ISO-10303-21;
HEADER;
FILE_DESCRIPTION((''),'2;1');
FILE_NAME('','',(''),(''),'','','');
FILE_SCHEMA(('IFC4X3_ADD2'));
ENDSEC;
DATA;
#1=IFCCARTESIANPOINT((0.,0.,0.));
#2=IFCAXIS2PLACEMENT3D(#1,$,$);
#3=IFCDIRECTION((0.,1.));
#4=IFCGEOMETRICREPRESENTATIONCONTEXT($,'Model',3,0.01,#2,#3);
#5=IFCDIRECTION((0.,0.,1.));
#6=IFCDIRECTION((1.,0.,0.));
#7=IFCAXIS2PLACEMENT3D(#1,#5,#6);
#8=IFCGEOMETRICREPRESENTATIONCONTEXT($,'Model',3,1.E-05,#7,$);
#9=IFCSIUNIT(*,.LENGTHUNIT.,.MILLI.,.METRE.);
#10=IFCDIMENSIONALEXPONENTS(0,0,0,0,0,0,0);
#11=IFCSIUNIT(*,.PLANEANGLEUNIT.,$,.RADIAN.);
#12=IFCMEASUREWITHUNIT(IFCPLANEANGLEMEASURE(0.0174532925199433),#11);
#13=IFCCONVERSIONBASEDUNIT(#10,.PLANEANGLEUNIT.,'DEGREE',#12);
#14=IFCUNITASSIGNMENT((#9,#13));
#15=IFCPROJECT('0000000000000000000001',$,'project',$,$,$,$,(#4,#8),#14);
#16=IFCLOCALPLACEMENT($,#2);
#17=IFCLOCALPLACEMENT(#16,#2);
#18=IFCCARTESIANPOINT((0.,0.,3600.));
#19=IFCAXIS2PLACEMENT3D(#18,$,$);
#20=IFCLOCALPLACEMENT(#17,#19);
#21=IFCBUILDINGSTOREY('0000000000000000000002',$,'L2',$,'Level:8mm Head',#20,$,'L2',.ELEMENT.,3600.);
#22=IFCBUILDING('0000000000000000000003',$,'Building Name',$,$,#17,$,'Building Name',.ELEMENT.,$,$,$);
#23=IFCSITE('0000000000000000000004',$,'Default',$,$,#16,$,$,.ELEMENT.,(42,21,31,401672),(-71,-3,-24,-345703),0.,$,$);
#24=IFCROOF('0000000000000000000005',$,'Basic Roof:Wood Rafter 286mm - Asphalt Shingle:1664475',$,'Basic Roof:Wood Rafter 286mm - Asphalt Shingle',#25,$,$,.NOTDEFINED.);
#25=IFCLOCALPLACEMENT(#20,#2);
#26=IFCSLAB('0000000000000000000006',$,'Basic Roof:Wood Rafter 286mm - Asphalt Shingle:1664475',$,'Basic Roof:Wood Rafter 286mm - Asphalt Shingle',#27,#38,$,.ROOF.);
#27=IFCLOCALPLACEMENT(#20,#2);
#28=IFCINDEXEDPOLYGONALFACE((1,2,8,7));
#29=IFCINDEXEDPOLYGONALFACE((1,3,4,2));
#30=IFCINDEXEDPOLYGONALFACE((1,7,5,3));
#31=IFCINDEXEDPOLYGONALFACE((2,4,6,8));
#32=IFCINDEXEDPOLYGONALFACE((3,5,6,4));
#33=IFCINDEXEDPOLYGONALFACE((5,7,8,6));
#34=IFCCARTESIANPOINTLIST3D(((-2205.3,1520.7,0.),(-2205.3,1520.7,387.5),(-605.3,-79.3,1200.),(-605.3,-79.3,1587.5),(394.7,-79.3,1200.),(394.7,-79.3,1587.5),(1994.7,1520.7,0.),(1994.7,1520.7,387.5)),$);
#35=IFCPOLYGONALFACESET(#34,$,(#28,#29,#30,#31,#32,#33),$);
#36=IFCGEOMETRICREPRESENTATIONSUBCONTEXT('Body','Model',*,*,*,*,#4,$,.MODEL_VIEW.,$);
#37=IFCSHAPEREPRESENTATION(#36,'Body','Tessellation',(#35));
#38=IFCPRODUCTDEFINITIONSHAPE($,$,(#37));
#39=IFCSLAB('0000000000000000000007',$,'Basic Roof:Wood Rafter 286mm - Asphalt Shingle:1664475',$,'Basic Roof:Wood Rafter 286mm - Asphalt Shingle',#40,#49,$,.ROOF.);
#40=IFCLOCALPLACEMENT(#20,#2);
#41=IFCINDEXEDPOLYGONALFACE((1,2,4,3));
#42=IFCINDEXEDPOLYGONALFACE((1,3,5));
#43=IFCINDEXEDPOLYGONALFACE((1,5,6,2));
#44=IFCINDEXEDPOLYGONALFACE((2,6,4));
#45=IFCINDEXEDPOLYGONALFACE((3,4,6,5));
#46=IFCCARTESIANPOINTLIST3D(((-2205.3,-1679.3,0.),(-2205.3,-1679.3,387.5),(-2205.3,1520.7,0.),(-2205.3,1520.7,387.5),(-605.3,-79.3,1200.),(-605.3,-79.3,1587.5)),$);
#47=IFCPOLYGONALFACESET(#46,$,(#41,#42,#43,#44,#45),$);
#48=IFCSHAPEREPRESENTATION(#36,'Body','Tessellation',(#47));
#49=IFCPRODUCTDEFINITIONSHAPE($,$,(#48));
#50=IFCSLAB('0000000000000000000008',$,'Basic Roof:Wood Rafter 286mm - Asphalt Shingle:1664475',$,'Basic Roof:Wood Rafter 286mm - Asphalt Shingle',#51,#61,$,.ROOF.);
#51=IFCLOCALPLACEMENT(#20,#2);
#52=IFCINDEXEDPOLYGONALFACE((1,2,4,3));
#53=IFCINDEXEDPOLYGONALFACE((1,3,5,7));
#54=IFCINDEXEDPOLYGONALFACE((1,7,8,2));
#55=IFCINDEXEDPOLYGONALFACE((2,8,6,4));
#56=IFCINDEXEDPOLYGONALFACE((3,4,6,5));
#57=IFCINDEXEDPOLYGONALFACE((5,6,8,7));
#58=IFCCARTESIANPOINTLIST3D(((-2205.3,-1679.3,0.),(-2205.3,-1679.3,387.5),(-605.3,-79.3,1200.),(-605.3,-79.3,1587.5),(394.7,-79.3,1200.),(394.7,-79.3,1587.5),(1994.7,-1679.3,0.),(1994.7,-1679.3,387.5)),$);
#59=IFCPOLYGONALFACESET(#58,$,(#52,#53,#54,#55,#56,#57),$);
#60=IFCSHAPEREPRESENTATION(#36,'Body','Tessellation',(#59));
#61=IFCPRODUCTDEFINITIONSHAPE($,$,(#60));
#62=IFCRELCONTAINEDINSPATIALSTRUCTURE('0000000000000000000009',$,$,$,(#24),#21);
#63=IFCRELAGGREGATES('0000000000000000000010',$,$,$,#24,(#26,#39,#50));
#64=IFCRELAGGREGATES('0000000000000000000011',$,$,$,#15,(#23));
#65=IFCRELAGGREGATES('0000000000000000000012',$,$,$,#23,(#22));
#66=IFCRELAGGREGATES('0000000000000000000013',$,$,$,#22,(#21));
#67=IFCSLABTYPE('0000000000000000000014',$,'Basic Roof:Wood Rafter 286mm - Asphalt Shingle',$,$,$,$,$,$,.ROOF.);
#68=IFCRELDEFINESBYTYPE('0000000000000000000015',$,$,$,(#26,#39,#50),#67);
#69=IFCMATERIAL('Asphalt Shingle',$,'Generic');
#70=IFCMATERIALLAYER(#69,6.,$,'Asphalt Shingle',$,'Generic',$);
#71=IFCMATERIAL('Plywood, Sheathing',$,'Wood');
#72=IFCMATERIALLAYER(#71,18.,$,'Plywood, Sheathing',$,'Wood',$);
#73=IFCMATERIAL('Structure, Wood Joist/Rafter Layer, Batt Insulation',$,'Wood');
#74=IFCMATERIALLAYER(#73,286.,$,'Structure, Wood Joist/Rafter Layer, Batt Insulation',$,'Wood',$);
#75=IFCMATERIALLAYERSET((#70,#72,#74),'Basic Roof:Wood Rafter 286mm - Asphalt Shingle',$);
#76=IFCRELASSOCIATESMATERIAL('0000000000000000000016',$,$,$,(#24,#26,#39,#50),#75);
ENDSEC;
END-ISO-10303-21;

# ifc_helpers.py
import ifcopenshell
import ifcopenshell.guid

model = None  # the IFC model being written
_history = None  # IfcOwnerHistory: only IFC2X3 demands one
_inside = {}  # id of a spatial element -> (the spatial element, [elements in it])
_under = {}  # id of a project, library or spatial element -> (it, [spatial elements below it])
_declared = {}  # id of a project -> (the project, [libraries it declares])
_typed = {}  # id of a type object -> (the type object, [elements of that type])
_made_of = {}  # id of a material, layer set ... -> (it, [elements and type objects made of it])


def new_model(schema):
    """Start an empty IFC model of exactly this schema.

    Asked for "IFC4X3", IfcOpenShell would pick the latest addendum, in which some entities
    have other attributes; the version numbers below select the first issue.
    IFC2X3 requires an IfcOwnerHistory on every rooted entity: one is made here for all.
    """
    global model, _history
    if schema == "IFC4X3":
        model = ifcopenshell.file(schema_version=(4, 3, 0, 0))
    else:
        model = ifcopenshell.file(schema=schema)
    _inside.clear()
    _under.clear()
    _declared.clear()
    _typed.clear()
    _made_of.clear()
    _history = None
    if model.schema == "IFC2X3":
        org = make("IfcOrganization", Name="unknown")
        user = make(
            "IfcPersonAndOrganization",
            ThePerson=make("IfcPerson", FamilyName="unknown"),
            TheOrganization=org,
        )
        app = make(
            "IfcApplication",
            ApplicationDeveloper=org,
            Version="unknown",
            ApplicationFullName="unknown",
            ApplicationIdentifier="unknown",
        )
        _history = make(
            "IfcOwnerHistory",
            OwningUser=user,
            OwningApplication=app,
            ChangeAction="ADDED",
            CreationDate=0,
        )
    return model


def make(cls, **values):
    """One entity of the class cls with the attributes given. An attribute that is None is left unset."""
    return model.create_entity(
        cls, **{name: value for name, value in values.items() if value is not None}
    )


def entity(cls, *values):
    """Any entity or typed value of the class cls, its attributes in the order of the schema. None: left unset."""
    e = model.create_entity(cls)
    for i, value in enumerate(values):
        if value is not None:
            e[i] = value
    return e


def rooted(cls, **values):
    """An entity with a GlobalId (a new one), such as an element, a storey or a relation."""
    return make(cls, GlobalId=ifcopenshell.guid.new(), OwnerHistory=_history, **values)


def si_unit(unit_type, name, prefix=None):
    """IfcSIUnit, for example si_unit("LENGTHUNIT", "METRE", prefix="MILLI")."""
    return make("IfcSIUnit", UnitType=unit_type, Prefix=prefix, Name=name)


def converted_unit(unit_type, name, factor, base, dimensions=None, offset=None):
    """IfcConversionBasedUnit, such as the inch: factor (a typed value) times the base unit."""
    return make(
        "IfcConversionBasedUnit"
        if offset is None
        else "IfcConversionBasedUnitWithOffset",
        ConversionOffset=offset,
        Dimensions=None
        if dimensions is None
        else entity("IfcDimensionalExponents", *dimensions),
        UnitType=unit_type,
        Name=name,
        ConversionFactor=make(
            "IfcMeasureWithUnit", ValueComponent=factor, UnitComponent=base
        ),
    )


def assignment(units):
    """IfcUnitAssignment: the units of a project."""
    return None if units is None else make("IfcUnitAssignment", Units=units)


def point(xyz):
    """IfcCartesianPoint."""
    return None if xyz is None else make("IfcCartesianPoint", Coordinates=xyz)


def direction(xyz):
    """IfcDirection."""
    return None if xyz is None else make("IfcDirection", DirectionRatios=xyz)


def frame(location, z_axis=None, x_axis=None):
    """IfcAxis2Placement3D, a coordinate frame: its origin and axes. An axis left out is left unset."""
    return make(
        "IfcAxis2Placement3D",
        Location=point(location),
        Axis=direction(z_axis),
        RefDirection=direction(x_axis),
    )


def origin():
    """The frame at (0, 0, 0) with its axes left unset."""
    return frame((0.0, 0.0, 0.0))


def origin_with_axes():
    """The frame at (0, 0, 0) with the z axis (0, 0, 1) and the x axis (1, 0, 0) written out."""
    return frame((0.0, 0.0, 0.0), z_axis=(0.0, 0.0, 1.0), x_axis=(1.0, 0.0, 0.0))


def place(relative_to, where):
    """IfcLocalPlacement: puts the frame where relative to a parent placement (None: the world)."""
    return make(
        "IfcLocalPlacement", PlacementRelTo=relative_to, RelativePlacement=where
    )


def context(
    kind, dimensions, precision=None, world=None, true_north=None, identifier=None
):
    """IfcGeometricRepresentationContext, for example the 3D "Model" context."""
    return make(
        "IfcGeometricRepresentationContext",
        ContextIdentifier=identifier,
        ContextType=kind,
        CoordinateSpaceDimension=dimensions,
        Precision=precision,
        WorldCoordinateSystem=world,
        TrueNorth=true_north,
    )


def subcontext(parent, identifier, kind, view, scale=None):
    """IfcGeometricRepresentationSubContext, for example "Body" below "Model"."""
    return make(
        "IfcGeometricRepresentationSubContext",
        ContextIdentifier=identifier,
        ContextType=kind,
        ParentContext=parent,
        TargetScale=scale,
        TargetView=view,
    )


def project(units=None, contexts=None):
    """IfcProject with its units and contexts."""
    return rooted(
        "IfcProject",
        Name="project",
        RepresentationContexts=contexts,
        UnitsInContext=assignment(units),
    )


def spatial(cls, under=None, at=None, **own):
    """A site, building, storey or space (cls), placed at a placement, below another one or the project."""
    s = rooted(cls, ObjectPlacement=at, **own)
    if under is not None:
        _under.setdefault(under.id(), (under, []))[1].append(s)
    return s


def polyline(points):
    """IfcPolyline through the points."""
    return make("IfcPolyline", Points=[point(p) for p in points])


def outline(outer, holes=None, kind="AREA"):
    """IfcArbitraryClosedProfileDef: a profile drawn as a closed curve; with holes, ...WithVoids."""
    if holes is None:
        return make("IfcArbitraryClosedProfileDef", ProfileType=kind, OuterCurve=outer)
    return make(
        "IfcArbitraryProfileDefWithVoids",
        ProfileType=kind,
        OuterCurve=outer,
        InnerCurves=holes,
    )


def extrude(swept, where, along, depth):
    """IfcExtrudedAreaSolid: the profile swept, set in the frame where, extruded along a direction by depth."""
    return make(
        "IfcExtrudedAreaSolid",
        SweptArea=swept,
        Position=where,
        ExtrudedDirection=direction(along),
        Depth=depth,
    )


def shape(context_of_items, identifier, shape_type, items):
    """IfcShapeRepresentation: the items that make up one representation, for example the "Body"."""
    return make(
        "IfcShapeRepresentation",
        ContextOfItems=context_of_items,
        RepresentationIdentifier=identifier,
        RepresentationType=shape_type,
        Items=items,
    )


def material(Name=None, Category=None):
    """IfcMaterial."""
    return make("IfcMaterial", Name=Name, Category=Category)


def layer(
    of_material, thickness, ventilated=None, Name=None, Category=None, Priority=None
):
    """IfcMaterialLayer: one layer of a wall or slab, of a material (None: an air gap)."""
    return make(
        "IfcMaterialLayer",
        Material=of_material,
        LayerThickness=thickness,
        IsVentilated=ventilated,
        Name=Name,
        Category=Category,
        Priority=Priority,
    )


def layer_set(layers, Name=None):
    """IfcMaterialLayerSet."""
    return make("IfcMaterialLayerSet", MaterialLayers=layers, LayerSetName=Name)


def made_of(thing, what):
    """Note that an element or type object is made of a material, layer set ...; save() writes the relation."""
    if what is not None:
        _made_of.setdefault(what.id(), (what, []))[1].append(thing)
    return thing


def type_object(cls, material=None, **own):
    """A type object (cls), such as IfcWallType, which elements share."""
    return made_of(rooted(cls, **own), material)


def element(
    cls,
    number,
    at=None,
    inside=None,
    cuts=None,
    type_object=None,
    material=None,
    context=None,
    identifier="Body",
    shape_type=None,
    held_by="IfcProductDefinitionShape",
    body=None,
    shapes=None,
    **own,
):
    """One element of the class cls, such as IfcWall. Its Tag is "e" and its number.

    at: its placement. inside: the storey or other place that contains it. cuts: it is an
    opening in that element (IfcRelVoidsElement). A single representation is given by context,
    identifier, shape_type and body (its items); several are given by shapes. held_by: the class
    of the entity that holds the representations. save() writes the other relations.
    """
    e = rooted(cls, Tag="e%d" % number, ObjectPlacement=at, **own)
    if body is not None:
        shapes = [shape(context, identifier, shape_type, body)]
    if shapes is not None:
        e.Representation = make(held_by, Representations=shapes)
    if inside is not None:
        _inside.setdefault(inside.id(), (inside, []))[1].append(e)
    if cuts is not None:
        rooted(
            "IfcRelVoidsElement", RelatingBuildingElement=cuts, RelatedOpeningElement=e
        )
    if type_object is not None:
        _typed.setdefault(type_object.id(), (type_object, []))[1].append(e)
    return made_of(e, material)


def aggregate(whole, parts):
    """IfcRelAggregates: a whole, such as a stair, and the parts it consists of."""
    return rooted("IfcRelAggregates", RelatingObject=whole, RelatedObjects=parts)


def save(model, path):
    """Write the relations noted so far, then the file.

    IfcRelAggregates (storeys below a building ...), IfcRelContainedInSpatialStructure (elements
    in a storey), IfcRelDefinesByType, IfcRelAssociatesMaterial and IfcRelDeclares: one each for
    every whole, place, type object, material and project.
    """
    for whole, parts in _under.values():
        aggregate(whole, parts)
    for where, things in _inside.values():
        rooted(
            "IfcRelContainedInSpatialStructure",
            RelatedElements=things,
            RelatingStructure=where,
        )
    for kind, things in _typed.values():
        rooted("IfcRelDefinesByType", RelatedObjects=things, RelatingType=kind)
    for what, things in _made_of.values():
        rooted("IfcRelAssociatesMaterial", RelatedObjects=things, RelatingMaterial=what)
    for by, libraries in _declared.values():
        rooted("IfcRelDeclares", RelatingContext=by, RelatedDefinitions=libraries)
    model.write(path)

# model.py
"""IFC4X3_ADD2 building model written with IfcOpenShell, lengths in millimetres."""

from ifc_helpers import new_model, entity, si_unit, converted_unit, direction, frame, origin, origin_with_axes, place, context, subcontext, project, spatial, polyline, outline, extrude, material, layer, layer_set, type_object, element, aggregate, save


model = new_model("IFC4X3_ADD2")

# Units and contexts
model_context_1 = context("Model", 3, precision=0.01, world=origin(), true_north=direction((0.0, 1.0)))
model_context_2 = context("Model", 3, precision=1e-05, world=origin_with_axes())
body_context = subcontext(model_context_1, "Body", "Model", "MODEL_VIEW")
ifc_project = project(units=[si_unit("LENGTHUNIT", "METRE", prefix="MILLI"), converted_unit("PLANEANGLEUNIT", "DEGREE", entity("IfcPlaneAngleMeasure", 0.0174532925199433), si_unit("PLANEANGLEUNIT", "RADIAN"), dimensions=[0, 0, 0, 0, 0, 0, 0])], contexts=[model_context_1, model_context_2])

# Site, building, storey
site_placement = place(None, origin())
site = spatial("IfcSite", under=ifc_project, at=site_placement, Name="Default", CompositionType="ELEMENT", RefLatitude=(42, 21, 31, 401672), RefLongitude=(-71, -3, -24, -345703), RefElevation=0.0)
building_placement = place(site_placement, origin())
building = spatial("IfcBuilding", under=site, at=building_placement, Name="Building Name", LongName="Building Name", CompositionType="ELEMENT")
storey_placement = place(building_placement, frame((0.0, 0.0, 3600.0)))
storey = spatial("IfcBuildingStorey", under=building, at=storey_placement, Name="L2", ObjectType="Level:8mm Head", LongName="L2", CompositionType="ELEMENT", Elevation=3600.0)

# Roof, slabs
ifc_material_1 = material(Name="Asphalt Shingle", Category="Generic")
ifc_layer_1 = layer(ifc_material_1, 6.0, Name="Asphalt Shingle", Category="Generic")
ifc_material_2 = material(Name="Plywood, Sheathing", Category="Wood")
ifc_layer_2 = layer(ifc_material_2, 18.0, Name="Plywood, Sheathing", Category="Wood")
ifc_material_3 = material(Name="Structure, Wood Joist/Rafter Layer, Batt Insulation", Category="Wood")
ifc_layer_3 = layer(ifc_material_3, 286.0, Name="Structure, Wood Joist/Rafter Layer, Batt Insulation", Category="Wood")
ifc_layer_set = layer_set([ifc_layer_1, ifc_layer_2, ifc_layer_3], Name="Basic Roof:Wood Rafter 286mm - Asphalt Shingle")
roof_placement = place(storey_placement, frame((-2205.3, -1679.3, 0.0)))
roof = element("IfcRoof", 1, at=roof_placement, inside=storey, material=ifc_layer_set, Name="Basic Roof:Wood Rafter 286mm - Asphalt Shingle:1664475", ObjectType="Basic Roof:Wood Rafter 286mm - Asphalt Shingle", PredefinedType="NOTDEFINED")
slab_type = type_object("IfcSlabType", Name="Basic Roof:Wood Rafter 286mm - Asphalt Shingle", PredefinedType="ROOF")
slab_1_placement = place(roof_placement, origin())
slab_1 = element("IfcSlab", 2, at=slab_1_placement, type_object=slab_type, material=ifc_layer_set, Name="Basic Roof:Wood Rafter 286mm - Asphalt Shingle:1664475", ObjectType="Basic Roof:Wood Rafter 286mm - Asphalt Shingle", PredefinedType="ROOF", context=body_context, shape_type="SweptSolid", body=[
    extrude(outline(polyline([(2100.0, 1000.0), (-2100.0, 1000.0), (-500.0, -1000.0), (500.0, -1000.0), (2100.0, 1000.0)])), frame((2100.0, 2400.0, 600.0), z_axis=(0.0, 0.6, 0.8), x_axis=(1.0, 0.0, 0.0)), (0.0, -0.6, 0.8), 387.5),
])
slab_2_placement = place(roof_placement, origin())
slab_2 = element("IfcSlab", 3, at=slab_2_placement, type_object=slab_type, material=ifc_layer_set, Name="Basic Roof:Wood Rafter 286mm - Asphalt Shingle:1664475", ObjectType="Basic Roof:Wood Rafter 286mm - Asphalt Shingle", PredefinedType="ROOF", context=body_context, shape_type="SweptSolid", body=[
    extrude(outline(polyline([(-1000.0, 1600.0), (-1000.0, -1600.0), (1000.0, 0.0), (-1000.0, 1600.0)])), frame((800.0, 1600.0, 600.0), z_axis=(-0.6, 0.0, 0.8), x_axis=(0.8, 0.0, 0.6)), (0.6, 0.0, 0.8), 387.5),
])
slab_3_placement = place(roof_placement, origin())
slab_3 = element("IfcSlab", 4, at=slab_3_placement, type_object=slab_type, material=ifc_layer_set, Name="Basic Roof:Wood Rafter 286mm - Asphalt Shingle:1664475", ObjectType="Basic Roof:Wood Rafter 286mm - Asphalt Shingle", PredefinedType="ROOF", context=body_context, shape_type="SweptSolid", body=[
    extrude(outline(polyline([(-2100.0, -1000.0), (2100.0, -1000.0), (500.0, 1000.0), (-500.0, 1000.0), (-2100.0, -1000.0)])), frame((2100.0, 800.0, 600.0), z_axis=(0.0, -0.6, 0.8), x_axis=(1.0, 0.0, 0.0)), (0.0, 0.6, 0.8), 387.5),
])
aggregate(roof, [slab_1, slab_2, slab_3])

save(model, "model.ifc")
